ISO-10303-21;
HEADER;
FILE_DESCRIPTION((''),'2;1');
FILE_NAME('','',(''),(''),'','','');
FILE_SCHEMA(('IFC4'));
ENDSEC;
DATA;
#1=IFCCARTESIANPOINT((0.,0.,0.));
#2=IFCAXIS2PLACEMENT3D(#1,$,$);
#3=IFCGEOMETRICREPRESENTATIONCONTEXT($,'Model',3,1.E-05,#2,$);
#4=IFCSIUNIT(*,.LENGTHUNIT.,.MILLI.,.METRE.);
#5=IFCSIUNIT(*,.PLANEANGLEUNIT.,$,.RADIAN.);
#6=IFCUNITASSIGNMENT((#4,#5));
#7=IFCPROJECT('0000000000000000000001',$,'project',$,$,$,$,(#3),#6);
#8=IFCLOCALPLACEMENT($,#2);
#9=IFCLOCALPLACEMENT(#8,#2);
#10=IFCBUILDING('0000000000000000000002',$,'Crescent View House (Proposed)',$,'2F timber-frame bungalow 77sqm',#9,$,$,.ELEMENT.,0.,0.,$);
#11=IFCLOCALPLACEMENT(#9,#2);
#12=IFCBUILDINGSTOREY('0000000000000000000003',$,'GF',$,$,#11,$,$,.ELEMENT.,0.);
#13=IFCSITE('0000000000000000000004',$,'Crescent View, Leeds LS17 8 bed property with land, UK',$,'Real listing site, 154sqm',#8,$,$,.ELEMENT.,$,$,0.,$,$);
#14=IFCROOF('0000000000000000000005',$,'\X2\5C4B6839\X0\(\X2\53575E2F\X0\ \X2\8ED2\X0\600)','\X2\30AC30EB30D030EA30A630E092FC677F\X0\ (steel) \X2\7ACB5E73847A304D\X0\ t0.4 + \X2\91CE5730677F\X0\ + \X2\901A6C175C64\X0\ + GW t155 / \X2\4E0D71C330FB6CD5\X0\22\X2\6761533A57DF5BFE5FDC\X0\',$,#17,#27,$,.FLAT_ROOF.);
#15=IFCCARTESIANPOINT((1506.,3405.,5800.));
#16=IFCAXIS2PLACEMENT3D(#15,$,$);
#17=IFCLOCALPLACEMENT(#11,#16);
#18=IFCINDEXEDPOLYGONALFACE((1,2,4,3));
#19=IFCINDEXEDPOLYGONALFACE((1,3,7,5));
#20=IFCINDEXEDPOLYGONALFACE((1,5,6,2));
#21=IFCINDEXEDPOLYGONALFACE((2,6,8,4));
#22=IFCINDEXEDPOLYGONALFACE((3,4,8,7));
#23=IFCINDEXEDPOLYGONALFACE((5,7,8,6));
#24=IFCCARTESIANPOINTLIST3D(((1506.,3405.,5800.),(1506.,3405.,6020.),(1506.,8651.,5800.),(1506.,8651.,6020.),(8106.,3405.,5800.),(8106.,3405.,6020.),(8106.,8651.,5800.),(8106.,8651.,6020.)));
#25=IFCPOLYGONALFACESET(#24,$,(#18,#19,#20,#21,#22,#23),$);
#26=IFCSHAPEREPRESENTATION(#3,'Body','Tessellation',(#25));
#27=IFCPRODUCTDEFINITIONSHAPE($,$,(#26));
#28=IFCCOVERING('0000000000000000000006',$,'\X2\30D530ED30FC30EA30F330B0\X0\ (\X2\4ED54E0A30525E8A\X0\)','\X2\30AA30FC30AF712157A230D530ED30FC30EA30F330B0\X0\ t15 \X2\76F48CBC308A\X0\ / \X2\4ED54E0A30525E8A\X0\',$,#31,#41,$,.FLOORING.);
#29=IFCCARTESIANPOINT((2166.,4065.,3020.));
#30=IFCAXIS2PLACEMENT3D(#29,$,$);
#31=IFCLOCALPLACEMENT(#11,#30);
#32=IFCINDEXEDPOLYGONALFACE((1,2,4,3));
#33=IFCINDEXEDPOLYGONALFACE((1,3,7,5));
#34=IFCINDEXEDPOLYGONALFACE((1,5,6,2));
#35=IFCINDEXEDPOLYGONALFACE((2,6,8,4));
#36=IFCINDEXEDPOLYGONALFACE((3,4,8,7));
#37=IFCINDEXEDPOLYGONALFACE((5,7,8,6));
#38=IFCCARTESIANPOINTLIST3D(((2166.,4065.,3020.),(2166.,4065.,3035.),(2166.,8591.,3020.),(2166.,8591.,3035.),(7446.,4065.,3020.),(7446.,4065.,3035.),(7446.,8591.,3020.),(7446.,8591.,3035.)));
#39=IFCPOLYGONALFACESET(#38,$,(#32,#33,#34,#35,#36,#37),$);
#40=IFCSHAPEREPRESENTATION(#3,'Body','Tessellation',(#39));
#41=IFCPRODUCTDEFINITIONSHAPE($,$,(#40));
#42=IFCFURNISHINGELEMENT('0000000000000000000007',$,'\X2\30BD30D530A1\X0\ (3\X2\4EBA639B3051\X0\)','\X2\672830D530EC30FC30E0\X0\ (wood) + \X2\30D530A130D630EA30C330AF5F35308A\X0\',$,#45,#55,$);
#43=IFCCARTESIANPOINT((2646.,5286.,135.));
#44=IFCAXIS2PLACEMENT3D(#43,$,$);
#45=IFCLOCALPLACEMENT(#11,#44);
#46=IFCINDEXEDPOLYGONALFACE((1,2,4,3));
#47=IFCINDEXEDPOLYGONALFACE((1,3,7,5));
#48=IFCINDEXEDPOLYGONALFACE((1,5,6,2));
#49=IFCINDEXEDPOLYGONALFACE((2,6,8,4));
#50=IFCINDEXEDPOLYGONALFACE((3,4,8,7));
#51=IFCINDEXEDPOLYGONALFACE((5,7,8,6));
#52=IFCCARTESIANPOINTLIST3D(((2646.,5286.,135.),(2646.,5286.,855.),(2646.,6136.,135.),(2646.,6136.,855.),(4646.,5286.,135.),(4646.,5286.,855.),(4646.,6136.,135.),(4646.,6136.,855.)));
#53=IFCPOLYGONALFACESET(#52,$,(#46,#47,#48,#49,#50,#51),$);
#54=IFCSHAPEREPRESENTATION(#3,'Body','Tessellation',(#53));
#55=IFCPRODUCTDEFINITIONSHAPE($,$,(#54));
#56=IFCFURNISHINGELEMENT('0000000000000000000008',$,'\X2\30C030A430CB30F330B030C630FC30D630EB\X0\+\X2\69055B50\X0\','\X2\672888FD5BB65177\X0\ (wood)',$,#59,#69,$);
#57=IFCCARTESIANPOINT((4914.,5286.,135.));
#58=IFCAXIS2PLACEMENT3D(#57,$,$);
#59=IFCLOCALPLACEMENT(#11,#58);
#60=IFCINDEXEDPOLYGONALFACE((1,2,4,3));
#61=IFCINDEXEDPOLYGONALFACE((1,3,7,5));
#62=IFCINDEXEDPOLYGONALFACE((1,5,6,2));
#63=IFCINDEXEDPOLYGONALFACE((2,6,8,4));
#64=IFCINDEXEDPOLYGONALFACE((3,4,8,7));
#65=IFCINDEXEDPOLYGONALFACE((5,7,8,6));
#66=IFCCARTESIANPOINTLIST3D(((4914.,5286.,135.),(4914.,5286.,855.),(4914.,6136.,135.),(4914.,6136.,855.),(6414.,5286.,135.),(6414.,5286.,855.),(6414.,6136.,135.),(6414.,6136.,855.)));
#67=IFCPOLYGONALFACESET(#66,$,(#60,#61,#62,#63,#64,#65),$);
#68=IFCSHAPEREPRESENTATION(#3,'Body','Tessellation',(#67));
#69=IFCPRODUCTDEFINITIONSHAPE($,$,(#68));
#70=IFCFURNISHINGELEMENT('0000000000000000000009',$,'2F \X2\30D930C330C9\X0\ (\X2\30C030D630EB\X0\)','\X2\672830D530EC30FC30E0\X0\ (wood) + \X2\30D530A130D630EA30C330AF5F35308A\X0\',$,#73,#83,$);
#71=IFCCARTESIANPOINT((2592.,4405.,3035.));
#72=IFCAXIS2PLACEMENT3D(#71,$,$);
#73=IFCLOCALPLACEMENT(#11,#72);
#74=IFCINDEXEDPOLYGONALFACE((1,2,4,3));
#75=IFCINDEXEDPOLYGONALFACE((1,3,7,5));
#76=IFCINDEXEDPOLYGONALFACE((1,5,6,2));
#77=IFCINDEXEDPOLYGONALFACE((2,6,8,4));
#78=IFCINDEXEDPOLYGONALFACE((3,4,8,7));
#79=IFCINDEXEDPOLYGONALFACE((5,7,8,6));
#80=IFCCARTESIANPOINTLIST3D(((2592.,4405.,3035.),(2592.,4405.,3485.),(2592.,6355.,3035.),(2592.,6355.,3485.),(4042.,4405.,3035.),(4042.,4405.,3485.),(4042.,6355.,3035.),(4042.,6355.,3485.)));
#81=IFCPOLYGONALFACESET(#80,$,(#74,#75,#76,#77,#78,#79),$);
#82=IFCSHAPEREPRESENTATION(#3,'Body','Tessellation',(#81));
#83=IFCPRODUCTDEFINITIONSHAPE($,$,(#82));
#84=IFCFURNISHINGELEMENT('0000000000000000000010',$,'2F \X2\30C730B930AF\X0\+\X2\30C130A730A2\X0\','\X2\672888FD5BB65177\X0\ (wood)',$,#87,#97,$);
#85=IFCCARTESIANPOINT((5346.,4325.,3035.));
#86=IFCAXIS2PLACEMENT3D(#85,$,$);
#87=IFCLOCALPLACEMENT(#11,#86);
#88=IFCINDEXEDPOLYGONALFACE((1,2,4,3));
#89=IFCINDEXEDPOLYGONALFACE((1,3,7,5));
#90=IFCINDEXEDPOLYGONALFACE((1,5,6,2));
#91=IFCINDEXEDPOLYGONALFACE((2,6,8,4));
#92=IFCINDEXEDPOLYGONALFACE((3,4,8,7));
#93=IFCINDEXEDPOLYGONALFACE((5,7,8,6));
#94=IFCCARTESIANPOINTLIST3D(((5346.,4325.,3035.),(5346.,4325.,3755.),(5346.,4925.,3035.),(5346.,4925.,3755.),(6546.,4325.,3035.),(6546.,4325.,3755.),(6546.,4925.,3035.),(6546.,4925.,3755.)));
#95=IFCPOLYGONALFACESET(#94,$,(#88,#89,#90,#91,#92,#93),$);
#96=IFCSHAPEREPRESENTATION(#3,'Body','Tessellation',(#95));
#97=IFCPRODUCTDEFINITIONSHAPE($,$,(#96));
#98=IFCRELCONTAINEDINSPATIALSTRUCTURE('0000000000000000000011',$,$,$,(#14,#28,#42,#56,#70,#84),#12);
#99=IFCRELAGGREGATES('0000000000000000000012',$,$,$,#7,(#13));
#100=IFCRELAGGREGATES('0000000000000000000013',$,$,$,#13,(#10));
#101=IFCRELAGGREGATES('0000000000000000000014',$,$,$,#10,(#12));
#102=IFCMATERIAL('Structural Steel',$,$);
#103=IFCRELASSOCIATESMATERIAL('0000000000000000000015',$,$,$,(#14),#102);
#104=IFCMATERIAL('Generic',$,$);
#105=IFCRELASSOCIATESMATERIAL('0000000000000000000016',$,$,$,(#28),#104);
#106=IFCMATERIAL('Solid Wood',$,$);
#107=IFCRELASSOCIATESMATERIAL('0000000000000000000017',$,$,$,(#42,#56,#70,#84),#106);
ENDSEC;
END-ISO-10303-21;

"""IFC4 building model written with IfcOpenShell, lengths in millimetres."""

from ifc_helpers import new_model, si_unit, frame, frame_2d, origin, place, context, project, spatial, rectangle, extrude, material, element, save


model = new_model("IFC4")

# Units and contexts
model_context = context("Model", 3, precision=1e-05, world=origin())
ifc_project = project(units=[si_unit("LENGTHUNIT", "METRE", prefix="MILLI"), si_unit("PLANEANGLEUNIT", "RADIAN")], contexts=[model_context])

# Site, building, storey
site_placement = place(None, origin())
site = spatial("IfcSite", under=ifc_project, at=site_placement, Name="Crescent View, Leeds LS17 8 bed property with land, UK", ObjectType="Real listing site, 154sqm", CompositionType="ELEMENT", RefElevation=0.0)
building_placement = place(site_placement, origin())
building = spatial("IfcBuilding", under=site, at=building_placement, Name="Crescent View House (Proposed)", ObjectType="2F timber-frame bungalow 77sqm", CompositionType="ELEMENT", ElevationOfRefHeight=0.0, ElevationOfTerrain=0.0)
storey_placement = place(building_placement, origin())
storey = spatial("IfcBuildingStorey", under=building, at=storey_placement, Name="GF", CompositionType="ELEMENT", Elevation=0.0)

# Shared definitions
ifc_material_1 = material(Name="Solid Wood")

# Roof
ifc_material_2 = material(Name="Structural Steel")
for number, where, name in (
    (1, (1506.0, 3405.0, 5800.0), "屋根(南帯 軒600)"),
):
    element("IfcRoof", number, at=place(storey_placement, frame(where)), inside=storey, material=ifc_material_2, Name=name, Description="ガルバリウム鋼板 (steel) 立平葺き t0.4 + 野地板 + 通気層 + GW t155 / 不燃・法22条区域対応", PredefinedType="FLAT_ROOF", context=model_context, shape_type="SweptSolid", body=[
        extrude(rectangle(XDim=6600.0, YDim=5246.0, at=frame_2d((3300.0, 2623.0))), frame((1506.0, 3405.0, 5800.0)), (0.0, 0.0, 1.0), 220.0),
    ])

# Covering
ifc_material_3 = material(Name="Generic")
covering_placement = place(storey_placement, frame((2166.0, 4065.0, 3020.0)))
element("IfcCovering", 2, at=covering_placement, inside=storey, material=ifc_material_3, Name="フローリング (仕上げ床)", Description="オーク無垢フローリング t15 直貼り / 仕上げ床", PredefinedType="FLOORING", context=model_context, shape_type="SweptSolid", body=[
    extrude(rectangle(XDim=5280.0, YDim=4526.0, at=frame_2d((2640.0, 2263.0))), frame((2166.0, 4065.0, 3020.0)), (0.0, 0.0, 1.0), 15.0),
])

# Furnishing elements
furnishing_1_placement = place(storey_placement, frame((2646.0, 5286.0, 135.0)))
element("IfcFurnishingElement", 3, at=furnishing_1_placement, inside=storey, material=ifc_material_1, Name="ソファ (3人掛け)", Description="木フレーム (wood) + ファブリック張り", context=model_context, shape_type="SweptSolid", body=[
    extrude(rectangle(XDim=2000.0, YDim=850.0, at=frame_2d((1000.0, 425.0))), frame((2646.0, 5286.0, 135.0)), (0.0, 0.0, 1.0), 720.0),
])
furnishing_2_placement = place(storey_placement, frame((4914.0, 5286.0, 135.0)))
element("IfcFurnishingElement", 4, at=furnishing_2_placement, inside=storey, material=ifc_material_1, Name="ダイニングテーブル+椅子", Description="木製家具 (wood)", context=model_context, shape_type="SweptSolid", body=[
    extrude(rectangle(XDim=1500.0, YDim=850.0, at=frame_2d((750.0, 425.0))), frame((4914.0, 5286.0, 135.0)), (0.0, 0.0, 1.0), 720.0),
])
furnishing_3_placement = place(storey_placement, frame((2592.0, 4405.0, 3035.0)))
element("IfcFurnishingElement", 5, at=furnishing_3_placement, inside=storey, material=ifc_material_1, Name="2F ベッド (ダブル)", Description="木フレーム (wood) + ファブリック張り", context=model_context, shape_type="SweptSolid", body=[
    extrude(rectangle(XDim=1450.0, YDim=1950.0, at=frame_2d((725.0, 975.0))), frame((2592.0, 4405.0, 3035.0)), (0.0, 0.0, 1.0), 450.0),
])
furnishing_4_placement = place(storey_placement, frame((5346.0, 4325.0, 3035.0)))
element("IfcFurnishingElement", 6, at=furnishing_4_placement, inside=storey, material=ifc_material_1, Name="2F デスク+チェア", Description="木製家具 (wood)", context=model_context, shape_type="SweptSolid", body=[
    extrude(rectangle(XDim=1200.0, YDim=600.0, at=frame_2d((600.0, 300.0))), frame((5346.0, 4325.0, 3035.0)), (0.0, 0.0, 1.0), 720.0),
])

save(model, "model.ifc")
